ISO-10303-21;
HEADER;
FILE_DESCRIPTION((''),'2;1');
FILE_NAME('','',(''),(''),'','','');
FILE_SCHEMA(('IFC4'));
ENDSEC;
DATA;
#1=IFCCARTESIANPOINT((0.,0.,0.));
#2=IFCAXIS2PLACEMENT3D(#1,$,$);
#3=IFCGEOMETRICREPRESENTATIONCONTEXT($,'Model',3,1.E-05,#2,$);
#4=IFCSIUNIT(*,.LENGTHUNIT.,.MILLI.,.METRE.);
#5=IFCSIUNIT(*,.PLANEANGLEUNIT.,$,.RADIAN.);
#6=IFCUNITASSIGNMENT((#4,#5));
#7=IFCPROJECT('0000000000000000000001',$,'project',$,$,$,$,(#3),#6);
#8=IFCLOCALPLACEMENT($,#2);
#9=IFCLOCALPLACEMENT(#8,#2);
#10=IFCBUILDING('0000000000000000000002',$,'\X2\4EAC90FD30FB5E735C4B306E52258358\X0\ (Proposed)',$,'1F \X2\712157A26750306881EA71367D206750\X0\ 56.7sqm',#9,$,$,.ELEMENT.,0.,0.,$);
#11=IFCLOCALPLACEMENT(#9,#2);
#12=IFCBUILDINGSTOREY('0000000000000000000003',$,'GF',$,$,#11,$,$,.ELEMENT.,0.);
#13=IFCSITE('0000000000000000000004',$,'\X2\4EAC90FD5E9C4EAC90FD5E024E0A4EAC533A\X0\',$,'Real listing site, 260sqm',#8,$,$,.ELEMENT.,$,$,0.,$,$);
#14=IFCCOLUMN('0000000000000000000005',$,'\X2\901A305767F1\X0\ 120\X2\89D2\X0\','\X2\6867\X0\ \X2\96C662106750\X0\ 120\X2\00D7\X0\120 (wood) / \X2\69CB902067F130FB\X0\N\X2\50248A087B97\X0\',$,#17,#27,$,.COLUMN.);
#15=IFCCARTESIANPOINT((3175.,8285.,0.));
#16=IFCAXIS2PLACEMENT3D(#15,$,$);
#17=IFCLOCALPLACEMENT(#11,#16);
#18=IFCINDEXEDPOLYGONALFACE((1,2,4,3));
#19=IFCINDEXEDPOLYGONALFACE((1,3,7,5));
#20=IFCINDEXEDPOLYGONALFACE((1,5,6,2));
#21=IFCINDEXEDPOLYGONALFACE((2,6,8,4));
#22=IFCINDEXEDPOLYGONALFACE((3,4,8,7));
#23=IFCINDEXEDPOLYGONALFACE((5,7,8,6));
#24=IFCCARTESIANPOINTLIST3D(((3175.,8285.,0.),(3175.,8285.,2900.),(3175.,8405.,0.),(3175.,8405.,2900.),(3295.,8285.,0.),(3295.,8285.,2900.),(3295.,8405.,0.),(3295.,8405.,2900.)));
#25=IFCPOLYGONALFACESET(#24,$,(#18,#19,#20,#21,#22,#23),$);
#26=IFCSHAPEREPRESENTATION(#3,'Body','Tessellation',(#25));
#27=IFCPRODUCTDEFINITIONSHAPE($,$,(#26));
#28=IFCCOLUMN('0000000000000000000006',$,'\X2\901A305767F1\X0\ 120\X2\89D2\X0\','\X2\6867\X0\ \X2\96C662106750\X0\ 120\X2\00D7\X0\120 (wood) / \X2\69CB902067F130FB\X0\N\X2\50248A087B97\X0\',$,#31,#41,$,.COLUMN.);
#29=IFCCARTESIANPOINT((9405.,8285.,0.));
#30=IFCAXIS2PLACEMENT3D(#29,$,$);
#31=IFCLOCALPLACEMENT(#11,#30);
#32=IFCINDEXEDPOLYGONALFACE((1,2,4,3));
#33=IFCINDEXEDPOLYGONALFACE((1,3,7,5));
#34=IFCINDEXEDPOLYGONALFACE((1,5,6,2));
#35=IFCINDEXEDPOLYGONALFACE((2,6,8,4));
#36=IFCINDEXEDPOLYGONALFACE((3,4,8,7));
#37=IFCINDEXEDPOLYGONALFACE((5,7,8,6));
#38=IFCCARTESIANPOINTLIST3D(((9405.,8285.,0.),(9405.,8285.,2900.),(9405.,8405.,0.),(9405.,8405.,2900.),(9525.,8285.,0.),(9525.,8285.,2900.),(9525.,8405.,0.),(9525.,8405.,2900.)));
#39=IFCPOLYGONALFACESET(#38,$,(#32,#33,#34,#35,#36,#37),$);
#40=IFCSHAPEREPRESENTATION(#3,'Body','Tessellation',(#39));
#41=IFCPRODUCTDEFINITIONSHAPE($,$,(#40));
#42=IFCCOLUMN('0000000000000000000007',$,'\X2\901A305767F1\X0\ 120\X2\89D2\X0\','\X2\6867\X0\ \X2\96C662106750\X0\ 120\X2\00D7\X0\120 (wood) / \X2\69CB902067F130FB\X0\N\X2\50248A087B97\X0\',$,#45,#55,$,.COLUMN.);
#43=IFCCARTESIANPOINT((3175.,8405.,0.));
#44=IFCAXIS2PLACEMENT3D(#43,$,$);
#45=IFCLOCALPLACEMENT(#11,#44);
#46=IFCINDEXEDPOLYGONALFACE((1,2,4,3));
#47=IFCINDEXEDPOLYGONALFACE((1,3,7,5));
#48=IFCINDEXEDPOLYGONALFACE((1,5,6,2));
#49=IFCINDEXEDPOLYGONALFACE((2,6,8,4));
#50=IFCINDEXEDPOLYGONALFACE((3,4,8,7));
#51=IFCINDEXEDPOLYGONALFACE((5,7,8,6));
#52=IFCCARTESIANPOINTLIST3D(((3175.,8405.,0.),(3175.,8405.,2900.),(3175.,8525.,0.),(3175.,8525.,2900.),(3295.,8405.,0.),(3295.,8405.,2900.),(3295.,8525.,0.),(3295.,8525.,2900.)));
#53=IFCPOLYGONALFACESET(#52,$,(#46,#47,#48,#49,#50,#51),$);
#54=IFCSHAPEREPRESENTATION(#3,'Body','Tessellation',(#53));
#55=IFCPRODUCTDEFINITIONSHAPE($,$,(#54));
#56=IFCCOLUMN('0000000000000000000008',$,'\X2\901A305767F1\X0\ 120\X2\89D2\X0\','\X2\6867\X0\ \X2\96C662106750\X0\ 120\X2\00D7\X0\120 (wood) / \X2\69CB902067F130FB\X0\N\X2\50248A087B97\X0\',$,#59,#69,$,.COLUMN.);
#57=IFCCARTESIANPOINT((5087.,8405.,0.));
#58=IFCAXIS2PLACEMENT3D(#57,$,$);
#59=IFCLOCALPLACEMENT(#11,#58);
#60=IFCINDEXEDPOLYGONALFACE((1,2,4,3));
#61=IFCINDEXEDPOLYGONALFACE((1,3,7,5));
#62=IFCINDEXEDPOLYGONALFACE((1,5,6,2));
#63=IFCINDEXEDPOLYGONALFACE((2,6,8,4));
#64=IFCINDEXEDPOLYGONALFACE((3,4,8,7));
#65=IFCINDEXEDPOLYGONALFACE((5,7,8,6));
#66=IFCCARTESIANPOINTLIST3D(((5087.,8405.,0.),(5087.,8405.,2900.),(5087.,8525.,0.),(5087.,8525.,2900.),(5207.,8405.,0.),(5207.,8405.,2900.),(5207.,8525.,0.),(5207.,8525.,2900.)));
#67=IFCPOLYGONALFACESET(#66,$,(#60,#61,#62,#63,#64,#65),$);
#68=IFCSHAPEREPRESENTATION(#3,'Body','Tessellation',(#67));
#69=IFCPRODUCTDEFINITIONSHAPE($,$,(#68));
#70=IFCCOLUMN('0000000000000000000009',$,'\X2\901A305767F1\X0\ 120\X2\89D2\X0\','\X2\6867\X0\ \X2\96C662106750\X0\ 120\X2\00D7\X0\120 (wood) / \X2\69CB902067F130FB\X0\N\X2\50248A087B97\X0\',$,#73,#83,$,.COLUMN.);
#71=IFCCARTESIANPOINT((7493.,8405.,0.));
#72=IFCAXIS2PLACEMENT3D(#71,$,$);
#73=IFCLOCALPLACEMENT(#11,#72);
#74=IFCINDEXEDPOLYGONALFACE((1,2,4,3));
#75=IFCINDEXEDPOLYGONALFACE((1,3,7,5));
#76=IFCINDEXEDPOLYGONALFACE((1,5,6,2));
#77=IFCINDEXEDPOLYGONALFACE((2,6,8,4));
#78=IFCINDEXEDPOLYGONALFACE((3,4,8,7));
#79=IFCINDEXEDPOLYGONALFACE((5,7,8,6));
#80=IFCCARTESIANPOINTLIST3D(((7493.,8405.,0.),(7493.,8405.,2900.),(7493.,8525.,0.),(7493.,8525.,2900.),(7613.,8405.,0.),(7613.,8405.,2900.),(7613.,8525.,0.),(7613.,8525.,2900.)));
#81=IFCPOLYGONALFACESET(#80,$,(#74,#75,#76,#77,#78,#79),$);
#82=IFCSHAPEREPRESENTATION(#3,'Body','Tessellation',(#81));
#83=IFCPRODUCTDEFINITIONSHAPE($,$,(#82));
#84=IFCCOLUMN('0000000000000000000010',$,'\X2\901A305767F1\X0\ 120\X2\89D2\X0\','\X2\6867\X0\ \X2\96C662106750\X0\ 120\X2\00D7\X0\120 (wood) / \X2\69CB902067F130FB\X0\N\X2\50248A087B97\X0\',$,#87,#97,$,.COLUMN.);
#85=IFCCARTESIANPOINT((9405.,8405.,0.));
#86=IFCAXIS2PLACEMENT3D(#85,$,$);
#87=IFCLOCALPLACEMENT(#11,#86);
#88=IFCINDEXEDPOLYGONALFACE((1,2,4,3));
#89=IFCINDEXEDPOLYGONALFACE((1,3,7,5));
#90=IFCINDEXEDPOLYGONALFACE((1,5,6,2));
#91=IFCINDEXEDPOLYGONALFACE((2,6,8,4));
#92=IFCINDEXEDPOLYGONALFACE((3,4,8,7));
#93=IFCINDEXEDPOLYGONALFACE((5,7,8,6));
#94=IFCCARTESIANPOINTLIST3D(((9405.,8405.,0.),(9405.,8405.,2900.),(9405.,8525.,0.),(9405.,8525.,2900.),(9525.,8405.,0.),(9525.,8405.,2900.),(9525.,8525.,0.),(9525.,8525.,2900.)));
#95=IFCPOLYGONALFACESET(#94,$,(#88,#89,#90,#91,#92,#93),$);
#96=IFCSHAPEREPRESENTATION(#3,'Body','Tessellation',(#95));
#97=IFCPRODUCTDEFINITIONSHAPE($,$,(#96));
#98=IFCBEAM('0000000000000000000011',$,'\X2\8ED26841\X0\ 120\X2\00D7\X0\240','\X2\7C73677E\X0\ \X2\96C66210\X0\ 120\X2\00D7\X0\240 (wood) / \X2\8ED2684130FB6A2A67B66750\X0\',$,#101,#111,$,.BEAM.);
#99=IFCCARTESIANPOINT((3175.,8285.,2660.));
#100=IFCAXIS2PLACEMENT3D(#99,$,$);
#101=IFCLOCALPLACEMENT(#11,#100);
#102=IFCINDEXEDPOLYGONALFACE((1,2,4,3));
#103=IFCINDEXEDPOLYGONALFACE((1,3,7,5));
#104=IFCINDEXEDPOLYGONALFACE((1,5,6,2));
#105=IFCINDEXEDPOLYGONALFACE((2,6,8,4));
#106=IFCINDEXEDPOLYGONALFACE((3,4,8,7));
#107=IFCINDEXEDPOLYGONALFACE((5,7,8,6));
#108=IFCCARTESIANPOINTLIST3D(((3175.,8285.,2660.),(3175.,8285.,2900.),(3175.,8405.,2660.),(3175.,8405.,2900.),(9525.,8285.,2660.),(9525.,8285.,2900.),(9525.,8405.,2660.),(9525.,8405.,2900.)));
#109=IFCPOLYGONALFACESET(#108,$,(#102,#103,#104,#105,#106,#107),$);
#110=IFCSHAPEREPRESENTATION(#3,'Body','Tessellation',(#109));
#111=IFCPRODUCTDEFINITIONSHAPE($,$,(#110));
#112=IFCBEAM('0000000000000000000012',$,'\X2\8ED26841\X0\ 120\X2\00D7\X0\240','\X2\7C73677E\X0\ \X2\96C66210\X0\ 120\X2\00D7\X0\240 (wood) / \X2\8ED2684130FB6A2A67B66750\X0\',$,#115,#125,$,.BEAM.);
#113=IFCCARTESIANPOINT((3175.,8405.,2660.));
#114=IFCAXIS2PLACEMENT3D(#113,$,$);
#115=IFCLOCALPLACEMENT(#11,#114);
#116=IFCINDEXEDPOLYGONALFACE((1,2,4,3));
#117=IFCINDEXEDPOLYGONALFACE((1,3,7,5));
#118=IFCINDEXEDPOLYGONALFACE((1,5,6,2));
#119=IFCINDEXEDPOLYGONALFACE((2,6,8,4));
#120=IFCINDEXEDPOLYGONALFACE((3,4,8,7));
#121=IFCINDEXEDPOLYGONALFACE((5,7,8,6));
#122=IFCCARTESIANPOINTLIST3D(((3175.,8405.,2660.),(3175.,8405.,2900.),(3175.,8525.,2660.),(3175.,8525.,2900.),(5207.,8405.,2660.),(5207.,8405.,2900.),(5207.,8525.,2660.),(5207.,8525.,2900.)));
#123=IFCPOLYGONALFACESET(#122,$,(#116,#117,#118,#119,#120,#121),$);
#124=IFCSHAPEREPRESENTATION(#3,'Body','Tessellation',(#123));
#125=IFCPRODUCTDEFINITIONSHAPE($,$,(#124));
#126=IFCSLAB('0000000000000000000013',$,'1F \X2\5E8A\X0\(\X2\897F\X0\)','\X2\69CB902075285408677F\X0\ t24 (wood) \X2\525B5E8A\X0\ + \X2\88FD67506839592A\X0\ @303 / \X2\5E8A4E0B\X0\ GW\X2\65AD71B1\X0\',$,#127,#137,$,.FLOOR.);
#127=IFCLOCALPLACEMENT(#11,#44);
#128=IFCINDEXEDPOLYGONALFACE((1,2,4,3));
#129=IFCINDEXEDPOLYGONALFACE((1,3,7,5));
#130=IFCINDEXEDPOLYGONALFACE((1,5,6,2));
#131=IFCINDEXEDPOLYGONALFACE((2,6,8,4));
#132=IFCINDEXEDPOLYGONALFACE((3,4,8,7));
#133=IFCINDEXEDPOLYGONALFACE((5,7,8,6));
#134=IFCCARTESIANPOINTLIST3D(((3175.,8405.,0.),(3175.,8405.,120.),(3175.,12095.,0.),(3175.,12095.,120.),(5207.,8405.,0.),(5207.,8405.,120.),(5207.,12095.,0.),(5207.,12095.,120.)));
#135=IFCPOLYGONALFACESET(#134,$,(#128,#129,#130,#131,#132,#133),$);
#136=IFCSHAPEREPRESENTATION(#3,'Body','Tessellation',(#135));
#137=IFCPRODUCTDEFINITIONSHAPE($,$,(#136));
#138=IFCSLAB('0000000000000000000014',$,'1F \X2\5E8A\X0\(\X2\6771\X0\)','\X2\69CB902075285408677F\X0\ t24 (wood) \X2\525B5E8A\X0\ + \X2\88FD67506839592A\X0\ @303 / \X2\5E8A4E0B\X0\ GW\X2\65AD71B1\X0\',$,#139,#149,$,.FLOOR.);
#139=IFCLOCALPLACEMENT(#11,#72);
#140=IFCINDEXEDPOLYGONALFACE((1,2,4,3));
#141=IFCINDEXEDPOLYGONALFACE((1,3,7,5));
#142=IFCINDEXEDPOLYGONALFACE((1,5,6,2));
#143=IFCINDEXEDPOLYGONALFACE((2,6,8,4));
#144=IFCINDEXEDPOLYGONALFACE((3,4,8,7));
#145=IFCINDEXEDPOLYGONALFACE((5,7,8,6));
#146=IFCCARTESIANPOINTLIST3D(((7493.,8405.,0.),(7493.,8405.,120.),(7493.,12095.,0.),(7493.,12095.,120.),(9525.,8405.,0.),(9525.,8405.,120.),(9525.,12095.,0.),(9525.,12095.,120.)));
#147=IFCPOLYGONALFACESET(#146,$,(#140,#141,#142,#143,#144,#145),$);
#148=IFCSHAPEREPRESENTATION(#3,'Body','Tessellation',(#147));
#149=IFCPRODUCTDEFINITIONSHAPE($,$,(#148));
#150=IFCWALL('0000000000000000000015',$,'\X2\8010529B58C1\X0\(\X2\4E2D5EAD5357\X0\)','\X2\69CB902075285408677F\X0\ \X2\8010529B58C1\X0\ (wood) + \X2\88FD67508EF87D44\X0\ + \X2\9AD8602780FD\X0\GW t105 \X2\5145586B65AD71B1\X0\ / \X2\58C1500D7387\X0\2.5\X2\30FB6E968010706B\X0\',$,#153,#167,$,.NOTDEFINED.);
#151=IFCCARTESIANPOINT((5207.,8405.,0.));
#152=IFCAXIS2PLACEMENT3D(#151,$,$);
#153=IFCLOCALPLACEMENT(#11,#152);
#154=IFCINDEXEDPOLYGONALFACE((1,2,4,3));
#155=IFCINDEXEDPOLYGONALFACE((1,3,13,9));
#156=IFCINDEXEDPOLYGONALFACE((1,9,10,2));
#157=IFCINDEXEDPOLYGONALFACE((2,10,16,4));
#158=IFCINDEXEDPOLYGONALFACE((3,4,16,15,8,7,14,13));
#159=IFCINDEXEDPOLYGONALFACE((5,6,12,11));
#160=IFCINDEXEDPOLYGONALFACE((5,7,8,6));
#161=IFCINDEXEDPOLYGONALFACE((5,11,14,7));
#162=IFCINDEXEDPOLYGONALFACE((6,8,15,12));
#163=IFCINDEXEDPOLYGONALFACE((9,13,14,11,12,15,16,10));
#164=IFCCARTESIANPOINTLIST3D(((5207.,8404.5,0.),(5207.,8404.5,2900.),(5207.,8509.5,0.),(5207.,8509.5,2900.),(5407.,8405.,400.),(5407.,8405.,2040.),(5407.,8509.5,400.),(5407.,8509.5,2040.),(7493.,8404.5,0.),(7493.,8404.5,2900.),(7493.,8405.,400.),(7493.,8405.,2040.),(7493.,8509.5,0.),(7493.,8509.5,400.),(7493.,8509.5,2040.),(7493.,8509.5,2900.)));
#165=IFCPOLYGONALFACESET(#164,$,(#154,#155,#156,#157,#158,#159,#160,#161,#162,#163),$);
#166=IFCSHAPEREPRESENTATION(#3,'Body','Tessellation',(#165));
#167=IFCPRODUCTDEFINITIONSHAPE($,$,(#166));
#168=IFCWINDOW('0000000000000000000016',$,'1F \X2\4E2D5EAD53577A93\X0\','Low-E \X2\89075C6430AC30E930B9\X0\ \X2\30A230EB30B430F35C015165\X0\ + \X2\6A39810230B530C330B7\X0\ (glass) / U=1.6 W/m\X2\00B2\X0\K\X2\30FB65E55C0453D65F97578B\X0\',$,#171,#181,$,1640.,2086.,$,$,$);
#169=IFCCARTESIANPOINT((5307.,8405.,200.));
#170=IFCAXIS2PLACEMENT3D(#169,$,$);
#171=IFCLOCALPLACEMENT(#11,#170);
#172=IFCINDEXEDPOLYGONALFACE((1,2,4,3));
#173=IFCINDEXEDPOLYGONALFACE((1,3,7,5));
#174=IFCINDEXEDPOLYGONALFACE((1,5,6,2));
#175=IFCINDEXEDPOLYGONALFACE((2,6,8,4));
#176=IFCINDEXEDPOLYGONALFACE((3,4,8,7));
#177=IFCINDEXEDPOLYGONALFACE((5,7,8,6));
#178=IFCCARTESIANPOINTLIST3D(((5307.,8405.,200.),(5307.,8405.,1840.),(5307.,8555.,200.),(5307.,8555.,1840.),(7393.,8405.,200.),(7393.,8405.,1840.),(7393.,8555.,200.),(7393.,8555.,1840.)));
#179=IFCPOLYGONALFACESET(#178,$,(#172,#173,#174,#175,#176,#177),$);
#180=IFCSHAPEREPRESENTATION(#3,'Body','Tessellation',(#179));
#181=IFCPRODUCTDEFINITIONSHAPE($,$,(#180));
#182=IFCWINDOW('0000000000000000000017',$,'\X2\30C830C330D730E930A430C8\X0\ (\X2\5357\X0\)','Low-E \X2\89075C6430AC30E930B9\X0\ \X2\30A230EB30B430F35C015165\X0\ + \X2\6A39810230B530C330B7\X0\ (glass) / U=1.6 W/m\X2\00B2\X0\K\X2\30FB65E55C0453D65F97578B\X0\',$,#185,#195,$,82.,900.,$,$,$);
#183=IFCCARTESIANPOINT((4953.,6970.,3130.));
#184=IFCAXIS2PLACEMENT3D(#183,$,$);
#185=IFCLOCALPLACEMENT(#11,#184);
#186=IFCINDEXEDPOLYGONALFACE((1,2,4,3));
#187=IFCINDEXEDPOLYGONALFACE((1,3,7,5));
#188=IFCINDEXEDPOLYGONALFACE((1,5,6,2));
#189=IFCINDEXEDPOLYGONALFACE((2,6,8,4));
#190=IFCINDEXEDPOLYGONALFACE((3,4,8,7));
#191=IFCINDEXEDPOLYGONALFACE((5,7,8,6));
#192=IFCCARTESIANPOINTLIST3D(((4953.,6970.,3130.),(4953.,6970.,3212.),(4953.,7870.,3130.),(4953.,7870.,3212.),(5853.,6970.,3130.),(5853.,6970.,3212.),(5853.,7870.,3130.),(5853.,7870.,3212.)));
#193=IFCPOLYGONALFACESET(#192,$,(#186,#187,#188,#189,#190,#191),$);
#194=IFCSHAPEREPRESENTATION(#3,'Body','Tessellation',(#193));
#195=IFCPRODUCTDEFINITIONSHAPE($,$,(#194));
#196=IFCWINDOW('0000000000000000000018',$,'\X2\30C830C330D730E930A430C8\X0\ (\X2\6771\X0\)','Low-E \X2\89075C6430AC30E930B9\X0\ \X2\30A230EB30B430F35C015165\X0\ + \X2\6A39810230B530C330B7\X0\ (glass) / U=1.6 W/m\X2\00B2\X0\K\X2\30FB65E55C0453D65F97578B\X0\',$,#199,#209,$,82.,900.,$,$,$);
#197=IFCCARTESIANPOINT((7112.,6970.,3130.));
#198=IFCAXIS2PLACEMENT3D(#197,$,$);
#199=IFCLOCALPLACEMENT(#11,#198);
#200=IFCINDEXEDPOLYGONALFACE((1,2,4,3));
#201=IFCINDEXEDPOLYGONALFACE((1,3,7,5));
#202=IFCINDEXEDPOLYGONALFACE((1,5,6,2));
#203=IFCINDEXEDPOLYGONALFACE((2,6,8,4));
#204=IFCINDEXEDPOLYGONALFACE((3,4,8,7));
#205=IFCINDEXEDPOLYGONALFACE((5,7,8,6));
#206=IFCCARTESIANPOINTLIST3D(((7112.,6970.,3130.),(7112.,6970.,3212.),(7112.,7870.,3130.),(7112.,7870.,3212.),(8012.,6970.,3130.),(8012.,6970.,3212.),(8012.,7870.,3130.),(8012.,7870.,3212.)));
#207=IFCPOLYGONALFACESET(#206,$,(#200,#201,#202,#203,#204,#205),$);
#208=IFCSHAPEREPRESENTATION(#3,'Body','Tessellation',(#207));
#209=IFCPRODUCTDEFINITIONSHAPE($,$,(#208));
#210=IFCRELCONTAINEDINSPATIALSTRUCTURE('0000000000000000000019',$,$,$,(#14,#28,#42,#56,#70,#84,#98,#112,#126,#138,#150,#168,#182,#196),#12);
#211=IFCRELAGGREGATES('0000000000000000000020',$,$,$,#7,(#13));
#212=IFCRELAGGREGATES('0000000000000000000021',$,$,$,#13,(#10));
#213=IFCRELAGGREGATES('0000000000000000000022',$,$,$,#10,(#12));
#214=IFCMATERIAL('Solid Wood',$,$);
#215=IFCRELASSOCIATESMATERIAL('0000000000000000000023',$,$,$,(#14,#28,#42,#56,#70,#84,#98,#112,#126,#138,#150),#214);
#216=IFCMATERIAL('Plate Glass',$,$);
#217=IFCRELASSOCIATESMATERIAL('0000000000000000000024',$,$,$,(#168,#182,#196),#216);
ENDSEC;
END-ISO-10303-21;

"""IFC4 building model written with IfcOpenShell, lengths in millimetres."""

from ifc_helpers import new_model, si_unit, frame, frame_2d, origin, place, context, project, spatial, rectangle, extrude, material, element, fill, save


model = new_model("IFC4")

# Units and contexts
model_context = context("Model", 3, precision=1e-05, world=origin())
ifc_project = project(units=[si_unit("LENGTHUNIT", "METRE", prefix="MILLI"), si_unit("PLANEANGLEUNIT", "RADIAN")], contexts=[model_context])

# Site, building, storey
site_placement = place(None, origin())
site = spatial("IfcSite", under=ifc_project, at=site_placement, Name="京都府京都市上京区", ObjectType="Real listing site, 260sqm", CompositionType="ELEMENT", RefElevation=0.0)
building_placement = place(site_placement, origin())
building = spatial("IfcBuilding", under=site, at=building_placement, Name="京都・平屋の別荘 (Proposed)", ObjectType="1F 無垢材と自然素材 56.7sqm", CompositionType="ELEMENT", ElevationOfRefHeight=0.0, ElevationOfTerrain=0.0)
storey_placement = place(building_placement, origin())
storey = spatial("IfcBuildingStorey", under=building, at=storey_placement, Name="GF", CompositionType="ELEMENT", Elevation=0.0)

# Columns
ifc_material_1 = material(Name="Solid Wood")
column_1_placement = place(storey_placement, frame((3175.0, 8285.0, 0.0)))
element("IfcColumn", 1, at=column_1_placement, inside=storey, material=ifc_material_1, Name="通し柱 120角", Description="桧 集成材 120×120 (wood) / 構造柱・N値計算", PredefinedType="COLUMN", context=model_context, shape_type="SweptSolid", body=[
    extrude(rectangle(XDim=120.0, YDim=120.0, at=frame_2d((60.0, 60.0))), frame((3175.0, 8285.0, 0.0)), (0.0, 0.0, 1.0), 2900.0),
])
column_2_placement = place(storey_placement, frame((9405.0, 8285.0, 0.0)))
element("IfcColumn", 2, at=column_2_placement, inside=storey, material=ifc_material_1, Name="通し柱 120角", Description="桧 集成材 120×120 (wood) / 構造柱・N値計算", PredefinedType="COLUMN", context=model_context, shape_type="SweptSolid", body=[
    extrude(rectangle(XDim=120.0, YDim=120.0, at=frame_2d((60.0, 60.0))), frame((9405.0, 8285.0, 0.0)), (0.0, 0.0, 1.0), 2900.0),
])
column_3_placement = place(storey_placement, frame((3175.0, 8405.0, 0.0)))
element("IfcColumn", 3, at=column_3_placement, inside=storey, material=ifc_material_1, Name="通し柱 120角", Description="桧 集成材 120×120 (wood) / 構造柱・N値計算", PredefinedType="COLUMN", context=model_context, shape_type="SweptSolid", body=[
    extrude(rectangle(XDim=120.0, YDim=120.0, at=frame_2d((60.0, 60.0))), frame((3175.0, 8405.0, 0.0)), (0.0, 0.0, 1.0), 2900.0),
])
column_4_placement = place(storey_placement, frame((5087.0, 8405.0, 0.0)))
element("IfcColumn", 4, at=column_4_placement, inside=storey, material=ifc_material_1, Name="通し柱 120角", Description="桧 集成材 120×120 (wood) / 構造柱・N値計算", PredefinedType="COLUMN", context=model_context, shape_type="SweptSolid", body=[
    extrude(rectangle(XDim=120.0, YDim=120.0, at=frame_2d((60.0, 60.0))), frame((5087.0, 8405.0, 0.0)), (0.0, 0.0, 1.0), 2900.0),
])
column_5_placement = place(storey_placement, frame((7493.0, 8405.0, 0.0)))
element("IfcColumn", 5, at=column_5_placement, inside=storey, material=ifc_material_1, Name="通し柱 120角", Description="桧 集成材 120×120 (wood) / 構造柱・N値計算", PredefinedType="COLUMN", context=model_context, shape_type="SweptSolid", body=[
    extrude(rectangle(XDim=120.0, YDim=120.0, at=frame_2d((60.0, 60.0))), frame((7493.0, 8405.0, 0.0)), (0.0, 0.0, 1.0), 2900.0),
])
column_6_placement = place(storey_placement, frame((9405.0, 8405.0, 0.0)))
element("IfcColumn", 6, at=column_6_placement, inside=storey, material=ifc_material_1, Name="通し柱 120角", Description="桧 集成材 120×120 (wood) / 構造柱・N値計算", PredefinedType="COLUMN", context=model_context, shape_type="SweptSolid", body=[
    extrude(rectangle(XDim=120.0, YDim=120.0, at=frame_2d((60.0, 60.0))), frame((9405.0, 8405.0, 0.0)), (0.0, 0.0, 1.0), 2900.0),
])

# Beams
beam_1_placement = place(storey_placement, frame((3175.0, 8285.0, 2660.0)))
element("IfcBeam", 7, at=beam_1_placement, inside=storey, material=ifc_material_1, Name="軒桁 120×240", Description="米松 集成 120×240 (wood) / 軒桁・横架材", PredefinedType="BEAM", context=model_context, shape_type="SweptSolid", body=[
    extrude(rectangle(XDim=6350.0, YDim=120.0, at=frame_2d((3175.0, 60.0))), frame((3175.0, 8285.0, 2660.0)), (0.0, 0.0, 1.0), 240.0),
])
beam_2_placement = place(storey_placement, frame((3175.0, 8405.0, 2660.0)))
element("IfcBeam", 8, at=beam_2_placement, inside=storey, material=ifc_material_1, Name="軒桁 120×240", Description="米松 集成 120×240 (wood) / 軒桁・横架材", PredefinedType="BEAM", context=model_context, shape_type="SweptSolid", body=[
    extrude(rectangle(XDim=2032.0, YDim=120.0, at=frame_2d((1016.0, 60.0))), frame((3175.0, 8405.0, 2660.0)), (0.0, 0.0, 1.0), 240.0),
])

# Slabs
slab_1_placement = place(storey_placement, frame((3175.0, 8405.0, 0.0)))
element("IfcSlab", 9, at=slab_1_placement, inside=storey, material=ifc_material_1, Name="1F 床(西)", Description="構造用合板 t24 (wood) 剛床 + 製材根太 @303 / 床下 GW断熱", PredefinedType="FLOOR", context=model_context, shape_type="SweptSolid", body=[
    extrude(rectangle(XDim=2032.0, YDim=3690.0, at=frame_2d((1016.0, 1845.0))), frame((3175.0, 8405.0, 0.0)), (0.0, 0.0, 1.0), 120.0),
])
slab_2_placement = place(storey_placement, frame((7493.0, 8405.0, 0.0)))
element("IfcSlab", 10, at=slab_2_placement, inside=storey, material=ifc_material_1, Name="1F 床(東)", Description="構造用合板 t24 (wood) 剛床 + 製材根太 @303 / 床下 GW断熱", PredefinedType="FLOOR", context=model_context, shape_type="SweptSolid", body=[
    extrude(rectangle(XDim=2032.0, YDim=3690.0, at=frame_2d((1016.0, 1845.0))), frame((7493.0, 8405.0, 0.0)), (0.0, 0.0, 1.0), 120.0),
])

# Wall, opening, window
wall_1_placement = place(storey_placement, frame((5207.0, 8405.0, 0.0)))
wall_1 = element("IfcWall", 11, at=wall_1_placement, inside=storey, material=ifc_material_1, Name="耐力壁(中庭南)", Description="構造用合板 耐力壁 (wood) + 製材軸組 + 高性能GW t105 充填断熱 / 壁倍率2.5・準耐火", PredefinedType="NOTDEFINED", context=model_context, shape_type="SweptSolid", body=[
    extrude(rectangle(XDim=2286.0, YDim=105.0, at=frame_2d((1143.0, 52.0))), frame((5207.0, 8405.0, 0.0)), (0.0, 0.0, 1.0), 2900.0),
])
opening_placement = place(storey_placement, frame((5307.0, 8405.0, 200.0)))
opening = element("IfcOpeningElement", 12, at=opening_placement, cuts=wall_1, PredefinedType="NOTDEFINED", context=model_context, shape_type="SweptSolid", body=[
    extrude(rectangle(XDim=2086.0, YDim=150.0, at=frame_2d((1043.0, 75.0))), frame((5307.0, 8405.0, 200.0)), (0.0, 0.0, 1.0), 1640.0),
])
ifc_material_2 = material(Name="Plate Glass")
window_1_placement = place(storey_placement, frame((5307.0, 8405.0, 200.0)))
window_1 = element("IfcWindow", 13, at=window_1_placement, inside=storey, material=ifc_material_2, Name="1F 中庭南窓", Description="Low-E 複層ガラス アルゴン封入 + 樹脂サッシ (glass) / U=1.6 W/m²K・日射取得型", OverallHeight=1640.0, OverallWidth=2086.0, context=model_context, shape_type="SweptSolid", body=[
    extrude(rectangle(XDim=2086.0, YDim=150.0, at=frame_2d((1043.0, 75.0))), frame((5307.0, 8405.0, 200.0)), (0.0, 0.0, 1.0), 1640.0),
])
fill(opening, window_1)

# Windows
window_2_placement = place(storey_placement, frame((4953.0, 6970.0, 3130.0)))
element("IfcWindow", 14, at=window_2_placement, inside=storey, material=ifc_material_2, Name="トップライト (南)", Description="Low-E 複層ガラス アルゴン封入 + 樹脂サッシ (glass) / U=1.6 W/m²K・日射取得型", OverallHeight=82.0, OverallWidth=900.0, context=model_context, shape_type="SweptSolid", body=[
    extrude(rectangle(XDim=900.0, YDim=900.0, at=frame_2d((450.0, 450.0))), frame((4953.0, 6970.0, 3130.0)), (0.0, 0.0, 1.0), 82.0),
])
window_3_placement = place(storey_placement, frame((7112.0, 6970.0, 3130.0)))
element("IfcWindow", 15, at=window_3_placement, inside=storey, material=ifc_material_2, Name="トップライト (東)", Description="Low-E 複層ガラス アルゴン封入 + 樹脂サッシ (glass) / U=1.6 W/m²K・日射取得型", OverallHeight=82.0, OverallWidth=900.0, context=model_context, shape_type="SweptSolid", body=[
    extrude(rectangle(XDim=900.0, YDim=900.0, at=frame_2d((450.0, 450.0))), frame((7112.0, 6970.0, 3130.0)), (0.0, 0.0, 1.0), 82.0),
])

save(model, "model.ifc")
